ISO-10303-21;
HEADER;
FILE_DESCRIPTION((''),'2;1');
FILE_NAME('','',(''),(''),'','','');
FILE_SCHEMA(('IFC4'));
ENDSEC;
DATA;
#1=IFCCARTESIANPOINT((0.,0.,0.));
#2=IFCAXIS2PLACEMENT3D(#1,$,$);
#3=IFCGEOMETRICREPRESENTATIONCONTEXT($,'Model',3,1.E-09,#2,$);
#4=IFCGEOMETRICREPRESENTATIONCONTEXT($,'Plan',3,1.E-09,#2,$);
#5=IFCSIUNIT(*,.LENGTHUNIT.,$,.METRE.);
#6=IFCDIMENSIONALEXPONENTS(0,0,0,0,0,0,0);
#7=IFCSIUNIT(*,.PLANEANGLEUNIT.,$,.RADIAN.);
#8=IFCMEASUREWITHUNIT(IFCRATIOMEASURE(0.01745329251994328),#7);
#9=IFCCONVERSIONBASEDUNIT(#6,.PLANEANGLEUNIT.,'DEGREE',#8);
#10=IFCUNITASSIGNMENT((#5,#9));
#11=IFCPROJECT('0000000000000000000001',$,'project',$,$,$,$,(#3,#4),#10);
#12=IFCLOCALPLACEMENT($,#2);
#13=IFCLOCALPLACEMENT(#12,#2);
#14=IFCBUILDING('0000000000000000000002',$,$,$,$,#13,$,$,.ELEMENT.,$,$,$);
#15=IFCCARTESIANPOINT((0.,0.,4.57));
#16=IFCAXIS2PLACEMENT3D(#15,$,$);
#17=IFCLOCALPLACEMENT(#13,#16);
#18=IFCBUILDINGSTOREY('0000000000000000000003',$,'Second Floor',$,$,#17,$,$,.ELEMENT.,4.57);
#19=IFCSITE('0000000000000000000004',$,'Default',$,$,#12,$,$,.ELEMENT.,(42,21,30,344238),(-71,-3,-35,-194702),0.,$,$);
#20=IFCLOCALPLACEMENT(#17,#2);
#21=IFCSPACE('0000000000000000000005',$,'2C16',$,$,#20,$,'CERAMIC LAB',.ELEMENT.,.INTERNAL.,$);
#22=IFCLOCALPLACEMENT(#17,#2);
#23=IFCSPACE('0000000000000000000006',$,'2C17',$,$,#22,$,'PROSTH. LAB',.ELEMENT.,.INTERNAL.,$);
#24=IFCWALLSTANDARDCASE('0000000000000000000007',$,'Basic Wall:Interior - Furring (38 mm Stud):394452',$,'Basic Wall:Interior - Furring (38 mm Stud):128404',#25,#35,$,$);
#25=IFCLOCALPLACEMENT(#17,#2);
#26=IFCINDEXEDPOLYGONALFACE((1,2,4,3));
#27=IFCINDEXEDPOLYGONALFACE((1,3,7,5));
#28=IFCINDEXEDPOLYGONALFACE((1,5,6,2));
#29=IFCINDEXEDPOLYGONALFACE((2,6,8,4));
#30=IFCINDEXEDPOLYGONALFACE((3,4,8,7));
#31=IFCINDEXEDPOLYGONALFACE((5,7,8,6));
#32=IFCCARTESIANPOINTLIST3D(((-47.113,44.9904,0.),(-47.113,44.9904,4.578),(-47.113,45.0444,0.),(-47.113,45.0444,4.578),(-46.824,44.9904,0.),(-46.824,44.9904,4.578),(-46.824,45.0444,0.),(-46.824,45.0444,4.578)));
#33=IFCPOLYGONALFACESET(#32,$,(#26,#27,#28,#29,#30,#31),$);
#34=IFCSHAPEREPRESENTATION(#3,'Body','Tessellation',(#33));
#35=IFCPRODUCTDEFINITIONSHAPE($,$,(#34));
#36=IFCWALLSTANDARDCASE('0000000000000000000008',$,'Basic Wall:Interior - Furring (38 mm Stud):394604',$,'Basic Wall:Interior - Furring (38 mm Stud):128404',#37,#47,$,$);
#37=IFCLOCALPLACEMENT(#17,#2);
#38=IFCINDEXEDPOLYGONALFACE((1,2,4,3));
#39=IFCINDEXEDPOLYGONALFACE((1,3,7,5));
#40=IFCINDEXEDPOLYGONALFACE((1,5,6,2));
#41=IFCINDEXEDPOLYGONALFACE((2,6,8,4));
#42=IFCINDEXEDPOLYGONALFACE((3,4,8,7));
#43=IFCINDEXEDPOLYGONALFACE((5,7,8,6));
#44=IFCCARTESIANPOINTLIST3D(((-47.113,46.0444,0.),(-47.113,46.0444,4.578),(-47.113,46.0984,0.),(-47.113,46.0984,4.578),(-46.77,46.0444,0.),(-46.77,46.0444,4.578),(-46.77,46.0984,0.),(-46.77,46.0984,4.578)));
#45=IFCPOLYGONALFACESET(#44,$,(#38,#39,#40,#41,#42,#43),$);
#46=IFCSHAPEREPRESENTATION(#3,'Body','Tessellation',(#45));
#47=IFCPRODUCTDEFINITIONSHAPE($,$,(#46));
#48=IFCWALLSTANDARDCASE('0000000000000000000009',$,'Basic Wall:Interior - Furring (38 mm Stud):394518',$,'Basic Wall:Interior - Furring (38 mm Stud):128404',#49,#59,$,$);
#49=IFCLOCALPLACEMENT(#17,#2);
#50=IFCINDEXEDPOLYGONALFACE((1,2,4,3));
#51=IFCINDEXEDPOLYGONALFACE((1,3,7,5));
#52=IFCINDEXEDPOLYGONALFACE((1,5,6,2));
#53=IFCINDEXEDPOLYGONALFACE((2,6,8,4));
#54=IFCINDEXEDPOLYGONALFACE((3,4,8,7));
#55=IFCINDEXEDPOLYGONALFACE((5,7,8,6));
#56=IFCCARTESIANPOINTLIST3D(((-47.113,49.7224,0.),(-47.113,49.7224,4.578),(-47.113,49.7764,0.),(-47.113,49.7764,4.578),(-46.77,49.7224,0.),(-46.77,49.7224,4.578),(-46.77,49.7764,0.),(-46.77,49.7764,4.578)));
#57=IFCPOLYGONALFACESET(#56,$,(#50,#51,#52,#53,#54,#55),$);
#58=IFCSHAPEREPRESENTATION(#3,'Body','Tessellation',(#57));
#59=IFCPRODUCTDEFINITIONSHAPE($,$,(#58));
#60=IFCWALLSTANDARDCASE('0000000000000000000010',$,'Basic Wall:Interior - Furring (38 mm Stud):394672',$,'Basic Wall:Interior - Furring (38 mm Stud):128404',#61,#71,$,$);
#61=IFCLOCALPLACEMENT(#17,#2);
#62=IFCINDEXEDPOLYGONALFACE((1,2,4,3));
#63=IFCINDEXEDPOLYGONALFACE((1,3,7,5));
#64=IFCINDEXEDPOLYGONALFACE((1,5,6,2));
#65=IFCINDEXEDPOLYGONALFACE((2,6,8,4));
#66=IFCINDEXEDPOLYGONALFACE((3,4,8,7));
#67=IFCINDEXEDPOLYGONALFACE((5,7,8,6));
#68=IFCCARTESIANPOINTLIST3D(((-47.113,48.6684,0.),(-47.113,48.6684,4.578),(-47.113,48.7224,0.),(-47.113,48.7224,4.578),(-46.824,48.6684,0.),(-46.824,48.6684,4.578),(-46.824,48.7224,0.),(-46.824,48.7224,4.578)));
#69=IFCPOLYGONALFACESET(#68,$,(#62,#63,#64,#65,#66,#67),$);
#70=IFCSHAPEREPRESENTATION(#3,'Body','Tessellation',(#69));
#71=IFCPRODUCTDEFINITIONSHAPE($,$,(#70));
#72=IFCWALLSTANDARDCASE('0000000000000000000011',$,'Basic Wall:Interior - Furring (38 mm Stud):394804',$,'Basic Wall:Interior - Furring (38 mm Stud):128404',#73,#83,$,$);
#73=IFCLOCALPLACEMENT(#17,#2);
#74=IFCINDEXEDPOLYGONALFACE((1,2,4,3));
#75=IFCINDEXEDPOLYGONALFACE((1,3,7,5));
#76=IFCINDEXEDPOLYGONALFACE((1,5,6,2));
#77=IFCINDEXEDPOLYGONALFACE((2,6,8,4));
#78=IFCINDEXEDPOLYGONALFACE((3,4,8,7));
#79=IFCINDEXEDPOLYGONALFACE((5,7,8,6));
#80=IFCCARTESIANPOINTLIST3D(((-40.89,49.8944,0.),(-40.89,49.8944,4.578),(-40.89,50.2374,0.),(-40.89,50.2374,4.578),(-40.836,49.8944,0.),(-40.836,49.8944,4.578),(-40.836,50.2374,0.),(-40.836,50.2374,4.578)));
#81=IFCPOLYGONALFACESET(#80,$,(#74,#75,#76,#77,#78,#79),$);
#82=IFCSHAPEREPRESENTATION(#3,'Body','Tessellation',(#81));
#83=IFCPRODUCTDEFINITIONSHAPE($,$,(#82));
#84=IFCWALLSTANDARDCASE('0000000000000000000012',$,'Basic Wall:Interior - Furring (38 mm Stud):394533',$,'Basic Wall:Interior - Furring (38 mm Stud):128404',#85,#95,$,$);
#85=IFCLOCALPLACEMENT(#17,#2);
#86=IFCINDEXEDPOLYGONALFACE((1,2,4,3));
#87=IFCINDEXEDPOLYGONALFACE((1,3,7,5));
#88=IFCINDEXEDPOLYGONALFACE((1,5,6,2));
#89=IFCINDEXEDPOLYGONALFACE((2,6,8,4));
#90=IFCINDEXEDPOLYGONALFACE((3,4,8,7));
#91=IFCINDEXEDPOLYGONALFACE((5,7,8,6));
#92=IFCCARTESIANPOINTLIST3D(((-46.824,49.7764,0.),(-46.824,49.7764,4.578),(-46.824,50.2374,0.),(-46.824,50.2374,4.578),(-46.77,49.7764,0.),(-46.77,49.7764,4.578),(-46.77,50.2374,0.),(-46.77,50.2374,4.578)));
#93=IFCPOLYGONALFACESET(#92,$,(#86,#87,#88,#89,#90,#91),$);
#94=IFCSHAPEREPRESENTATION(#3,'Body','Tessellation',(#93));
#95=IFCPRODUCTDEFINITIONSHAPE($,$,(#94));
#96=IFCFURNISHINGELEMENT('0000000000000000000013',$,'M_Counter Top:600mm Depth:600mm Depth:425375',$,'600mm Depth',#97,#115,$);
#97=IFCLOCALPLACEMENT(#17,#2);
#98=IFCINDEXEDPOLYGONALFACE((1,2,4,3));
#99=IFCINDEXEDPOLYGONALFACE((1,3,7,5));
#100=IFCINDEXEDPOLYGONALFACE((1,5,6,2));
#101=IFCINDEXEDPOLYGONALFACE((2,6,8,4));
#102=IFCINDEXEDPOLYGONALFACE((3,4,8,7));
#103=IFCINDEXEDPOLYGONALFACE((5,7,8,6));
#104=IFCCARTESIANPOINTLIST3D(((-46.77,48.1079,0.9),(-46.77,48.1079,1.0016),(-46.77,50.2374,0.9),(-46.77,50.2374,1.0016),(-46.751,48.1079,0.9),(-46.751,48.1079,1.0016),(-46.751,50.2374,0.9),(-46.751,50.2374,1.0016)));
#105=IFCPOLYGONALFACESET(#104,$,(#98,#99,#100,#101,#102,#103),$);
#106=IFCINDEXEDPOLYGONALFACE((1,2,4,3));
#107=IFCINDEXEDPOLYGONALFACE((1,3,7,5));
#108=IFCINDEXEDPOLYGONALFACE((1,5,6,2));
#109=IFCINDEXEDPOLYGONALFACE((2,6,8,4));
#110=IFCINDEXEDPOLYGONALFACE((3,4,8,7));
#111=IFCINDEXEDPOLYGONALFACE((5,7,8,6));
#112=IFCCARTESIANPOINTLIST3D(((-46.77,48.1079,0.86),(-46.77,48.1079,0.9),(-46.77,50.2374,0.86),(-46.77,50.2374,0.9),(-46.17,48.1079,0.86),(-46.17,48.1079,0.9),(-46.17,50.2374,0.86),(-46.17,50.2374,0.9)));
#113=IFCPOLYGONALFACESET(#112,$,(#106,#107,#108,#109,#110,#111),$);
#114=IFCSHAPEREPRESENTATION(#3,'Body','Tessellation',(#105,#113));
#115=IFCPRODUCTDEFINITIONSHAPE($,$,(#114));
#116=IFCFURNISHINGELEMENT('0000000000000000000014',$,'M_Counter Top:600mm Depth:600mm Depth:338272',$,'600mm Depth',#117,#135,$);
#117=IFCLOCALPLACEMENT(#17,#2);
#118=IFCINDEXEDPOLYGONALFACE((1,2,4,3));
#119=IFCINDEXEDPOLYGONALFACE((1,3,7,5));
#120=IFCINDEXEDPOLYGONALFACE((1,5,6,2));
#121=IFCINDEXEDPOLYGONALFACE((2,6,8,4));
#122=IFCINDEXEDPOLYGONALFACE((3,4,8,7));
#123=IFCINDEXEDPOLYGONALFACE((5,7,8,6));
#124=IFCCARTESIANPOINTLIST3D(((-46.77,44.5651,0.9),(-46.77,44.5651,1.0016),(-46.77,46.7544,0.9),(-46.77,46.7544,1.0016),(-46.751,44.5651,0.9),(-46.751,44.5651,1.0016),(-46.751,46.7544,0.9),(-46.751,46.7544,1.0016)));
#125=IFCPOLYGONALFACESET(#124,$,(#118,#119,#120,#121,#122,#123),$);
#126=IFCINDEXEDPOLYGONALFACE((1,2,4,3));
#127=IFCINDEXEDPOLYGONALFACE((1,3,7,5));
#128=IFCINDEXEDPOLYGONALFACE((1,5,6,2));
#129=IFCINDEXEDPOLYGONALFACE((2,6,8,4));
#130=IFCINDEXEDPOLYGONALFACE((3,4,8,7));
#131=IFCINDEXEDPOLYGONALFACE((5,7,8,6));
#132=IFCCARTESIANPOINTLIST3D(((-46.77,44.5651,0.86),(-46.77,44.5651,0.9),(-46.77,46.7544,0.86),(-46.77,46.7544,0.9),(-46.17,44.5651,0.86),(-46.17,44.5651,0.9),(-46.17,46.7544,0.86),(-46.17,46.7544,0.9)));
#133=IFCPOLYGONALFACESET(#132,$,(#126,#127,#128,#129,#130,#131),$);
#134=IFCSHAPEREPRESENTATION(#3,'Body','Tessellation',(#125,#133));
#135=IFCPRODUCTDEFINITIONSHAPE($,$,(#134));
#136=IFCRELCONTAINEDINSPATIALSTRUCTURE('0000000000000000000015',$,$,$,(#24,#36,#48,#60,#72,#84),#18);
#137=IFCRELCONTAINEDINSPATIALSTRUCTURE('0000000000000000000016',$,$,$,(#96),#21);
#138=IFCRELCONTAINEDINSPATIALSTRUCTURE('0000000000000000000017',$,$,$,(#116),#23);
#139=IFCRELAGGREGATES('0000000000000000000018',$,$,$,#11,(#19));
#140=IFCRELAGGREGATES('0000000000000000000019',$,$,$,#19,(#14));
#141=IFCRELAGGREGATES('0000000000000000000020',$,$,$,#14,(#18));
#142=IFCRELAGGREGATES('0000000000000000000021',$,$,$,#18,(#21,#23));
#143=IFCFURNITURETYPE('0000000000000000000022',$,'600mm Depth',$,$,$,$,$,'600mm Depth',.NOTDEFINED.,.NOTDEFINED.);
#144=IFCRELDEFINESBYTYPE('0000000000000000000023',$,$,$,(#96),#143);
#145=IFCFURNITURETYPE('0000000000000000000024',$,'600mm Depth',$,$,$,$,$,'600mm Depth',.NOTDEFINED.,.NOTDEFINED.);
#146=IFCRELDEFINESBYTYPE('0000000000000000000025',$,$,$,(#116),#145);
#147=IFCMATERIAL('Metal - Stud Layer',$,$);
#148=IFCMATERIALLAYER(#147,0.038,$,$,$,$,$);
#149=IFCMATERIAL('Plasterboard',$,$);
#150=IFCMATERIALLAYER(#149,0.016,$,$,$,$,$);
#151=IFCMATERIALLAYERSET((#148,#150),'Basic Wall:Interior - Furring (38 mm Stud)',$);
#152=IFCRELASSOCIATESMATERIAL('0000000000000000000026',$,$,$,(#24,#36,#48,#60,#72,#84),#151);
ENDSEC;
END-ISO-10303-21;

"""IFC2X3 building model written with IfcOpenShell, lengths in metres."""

from ifc_helpers import new_model, entity, si_unit, converted_unit, frame, frame_2d, origin, origin_2d_with_axis, place, context, project, spatial, rectangle, extrude, source, transform, mapped, material, layer, layer_set, layer_usage, type_object, type_shapes, element, save


model = new_model("IFC2X3")

# Units and contexts
model_context = context("Model", 3, precision=1e-09, world=origin())
plan_context = context("Plan", 3, precision=1e-09, world=origin())
ifc_project = project(units=[si_unit("LENGTHUNIT", "METRE"), converted_unit("PLANEANGLEUNIT", "DEGREE", entity("IfcRatioMeasure", 0.01745329251994328), si_unit("PLANEANGLEUNIT", "RADIAN"), dimensions=[0, 0, 0, 0, 0, 0, 0])], contexts=[model_context, plan_context])

# Site, building, storey
site_placement = place(None, origin())
site = spatial("IfcSite", under=ifc_project, at=site_placement, Name="Default", CompositionType="ELEMENT", RefLatitude=(42, 21, 30, 344238), RefLongitude=(-71, -3, -35, -194702), RefElevation=0.0)
building_placement = place(site_placement, origin())
building = spatial("IfcBuilding", under=site, at=building_placement, CompositionType="ELEMENT")
storey_placement = place(building_placement, frame((0.0, 0.0, 4.57)))
storey = spatial("IfcBuildingStorey", under=building, at=storey_placement, Name="Second Floor", CompositionType="ELEMENT", Elevation=4.57)

# Shared definitions
ifc_material_1 = material(Name="Plasterboard")
ifc_material_2 = material(Name="Metal - Stud Layer")

# Shared definitions
ifc_layer_1 = layer(ifc_material_2, 0.038)
ifc_layer_2 = layer(ifc_material_1, 0.016)
ifc_layer_set_1 = layer_set([ifc_layer_1, ifc_layer_2], Name="Basic Wall:Interior - Furring (38 mm Stud)")
ifc_layer_usage_1 = layer_usage(ifc_layer_set_1, "AXIS2", "NEGATIVE", 0.027)

# Walls
wall_1_placement = place(storey_placement, frame((-46.824, 45.0174, 0.0), z_axis=(0.0, 0.0, 1.0), x_axis=(-1.0, 0.0, 0.0)))
element("IfcWallStandardCase", 1, at=wall_1_placement, inside=storey, material=ifc_layer_usage_1, Name="Basic Wall:Interior - Furring (38 mm Stud):394452", ObjectType="Basic Wall:Interior - Furring (38 mm Stud):128404", context=model_context, shape_type="SweptSolid", body=[
    extrude(rectangle(XDim=0.289, YDim=0.054, at=frame_2d((0.1445, 0.0), x_axis=(-1.0, 0.0))), origin(), (0.0, 0.0, 1.0), 4.578),
])
wall_2_placement = place(storey_placement, frame((-47.113, 46.0714, 0.0)))
element("IfcWallStandardCase", 2, at=wall_2_placement, inside=storey, material=ifc_layer_usage_1, Name="Basic Wall:Interior - Furring (38 mm Stud):394604", ObjectType="Basic Wall:Interior - Furring (38 mm Stud):128404", context=model_context, shape_type="SweptSolid", body=[
    extrude(rectangle(XDim=0.343, YDim=0.054, at=frame_2d((0.1715, 0.0), x_axis=(-1.0, 0.0))), origin(), (0.0, 0.0, 1.0), 4.578),
])
wall_3_placement = place(storey_placement, frame((-47.113, 49.7494, 0.0)))
element("IfcWallStandardCase", 3, at=wall_3_placement, inside=storey, material=ifc_layer_usage_1, Name="Basic Wall:Interior - Furring (38 mm Stud):394518", ObjectType="Basic Wall:Interior - Furring (38 mm Stud):128404", context=model_context, shape_type="SweptSolid", body=[
    extrude(rectangle(XDim=0.343, YDim=0.054, at=frame_2d((0.1715, 0.0), x_axis=(-1.0, 0.0))), origin(), (0.0, 0.0, 1.0), 4.578),
])
wall_4_placement = place(storey_placement, frame((-46.824, 48.6954, 0.0), z_axis=(0.0, 0.0, 1.0), x_axis=(-1.0, 0.0, 0.0)))
element("IfcWallStandardCase", 4, at=wall_4_placement, inside=storey, material=ifc_layer_usage_1, Name="Basic Wall:Interior - Furring (38 mm Stud):394672", ObjectType="Basic Wall:Interior - Furring (38 mm Stud):128404", context=model_context, shape_type="SweptSolid", body=[
    extrude(rectangle(XDim=0.289, YDim=0.054, at=frame_2d((0.1445, 0.0), x_axis=(-1.0, 0.0))), origin(), (0.0, 0.0, 1.0), 4.578),
])
wall_5_placement = place(storey_placement, frame((-40.863, 50.2374, 0.0), z_axis=(0.0, 0.0, 1.0), x_axis=(0.0, -1.0, 0.0)))
element("IfcWallStandardCase", 5, at=wall_5_placement, inside=storey, material=ifc_layer_usage_1, Name="Basic Wall:Interior - Furring (38 mm Stud):394804", ObjectType="Basic Wall:Interior - Furring (38 mm Stud):128404", context=model_context, shape_type="SweptSolid", body=[
    extrude(rectangle(XDim=0.343, YDim=0.054, at=frame_2d((0.1715, 0.0), x_axis=(-1.0, 0.0))), origin(), (0.0, 0.0, 1.0), 4.578),
])
wall_6_placement = place(storey_placement, frame((-46.797, 49.7764, 0.0), z_axis=(0.0, 0.0, 1.0), x_axis=(0.0, 1.0, 0.0)))
element("IfcWallStandardCase", 6, at=wall_6_placement, inside=storey, material=ifc_layer_usage_1, Name="Basic Wall:Interior - Furring (38 mm Stud):394533", ObjectType="Basic Wall:Interior - Furring (38 mm Stud):128404", context=model_context, shape_type="SweptSolid", body=[
    extrude(rectangle(XDim=0.461, YDim=0.054, at=frame_2d((0.2305, 0.0), x_axis=(-1.0, 0.0))), origin(), (0.0, 0.0, 1.0), 4.578),
])

# Shared definitions
space_1_placement = place(storey_placement, origin())
space_1 = spatial("IfcSpace", under=storey, at=space_1_placement, Name="2C16", LongName="CERAMIC LAB", CompositionType="ELEMENT", InteriorOrExteriorSpace="INTERNAL")

# Furnishing element
furniture_type_1 = type_object("IfcFurnitureType", Name="600mm Depth", ElementType="600mm Depth", AssemblyPlace="NOTDEFINED")
shared_shape_1 = source(origin(), model_context, "Body", "SweptSolid", [
    extrude(rectangle(XDim=0.0191, YDim=2.1295, at=origin_2d_with_axis()), frame((-0.1357, -0.0095, 0.9), z_axis=(0.0, 0.0, 1.0), x_axis=(0.0, -1.0, 0.0)), (0.0, 0.0, 1.0), 0.1016),
    extrude(rectangle(XDim=2.1295, YDim=0.6, at=origin_2d_with_axis()), frame((-0.1357, -0.3, 0.86), z_axis=(0.0, 0.0, 1.0), x_axis=(-1.0, 0.0, 0.0)), (0.0, 0.0, 1.0), 0.04),
])
type_shapes(furniture_type_1, [shared_shape_1])
furnishing_1_placement = place(space_1_placement, frame((-46.77, 49.3084, 0.0), z_axis=(0.0, 0.0, 1.0), x_axis=(0.0, 1.0, 0.0)))
element("IfcFurnishingElement", 7, at=furnishing_1_placement, inside=space_1, type_object=furniture_type_1, Name="M_Counter Top:600mm Depth:600mm Depth:425375", ObjectType="600mm Depth", context=model_context, shape_type="MappedRepresentation", body=[
    mapped(shared_shape_1, transform((0.0, 0.0, 0.0), scale=1.0)),
])

# Shared definitions
space_2_placement = place(storey_placement, origin())
space_2 = spatial("IfcSpace", under=storey, at=space_2_placement, Name="2C17", LongName="PROSTH. LAB", CompositionType="ELEMENT", InteriorOrExteriorSpace="INTERNAL")

# Furnishing element
furniture_type_2 = type_object("IfcFurnitureType", Name="600mm Depth", ElementType="600mm Depth", AssemblyPlace="NOTDEFINED")
shared_shape_2 = source(origin(), model_context, "Body", "SweptSolid", [
    extrude(rectangle(XDim=0.0191, YDim=2.1893, at=origin_2d_with_axis()), frame((-0.1058, -0.0095, 0.9), z_axis=(0.0, 0.0, 1.0), x_axis=(0.0, -1.0, 0.0)), (0.0, 0.0, 1.0), 0.1016),
    extrude(rectangle(XDim=2.1893, YDim=0.6, at=origin_2d_with_axis()), frame((-0.1058, -0.3, 0.86), z_axis=(0.0, 0.0, 1.0), x_axis=(-1.0, 0.0, 0.0)), (0.0, 0.0, 1.0), 0.04),
])
type_shapes(furniture_type_2, [shared_shape_2])
furnishing_2_placement = place(space_2_placement, frame((-46.77, 45.7656, 0.0), z_axis=(0.0, 0.0, 1.0), x_axis=(0.0, 1.0, 0.0)))
element("IfcFurnishingElement", 8, at=furnishing_2_placement, inside=space_2, type_object=furniture_type_2, Name="M_Counter Top:600mm Depth:600mm Depth:338272", ObjectType="600mm Depth", context=model_context, shape_type="MappedRepresentation", body=[
    mapped(shared_shape_2, transform((0.0, 0.0, 0.0), scale=1.0)),
])

save(model, "model.ifc")
